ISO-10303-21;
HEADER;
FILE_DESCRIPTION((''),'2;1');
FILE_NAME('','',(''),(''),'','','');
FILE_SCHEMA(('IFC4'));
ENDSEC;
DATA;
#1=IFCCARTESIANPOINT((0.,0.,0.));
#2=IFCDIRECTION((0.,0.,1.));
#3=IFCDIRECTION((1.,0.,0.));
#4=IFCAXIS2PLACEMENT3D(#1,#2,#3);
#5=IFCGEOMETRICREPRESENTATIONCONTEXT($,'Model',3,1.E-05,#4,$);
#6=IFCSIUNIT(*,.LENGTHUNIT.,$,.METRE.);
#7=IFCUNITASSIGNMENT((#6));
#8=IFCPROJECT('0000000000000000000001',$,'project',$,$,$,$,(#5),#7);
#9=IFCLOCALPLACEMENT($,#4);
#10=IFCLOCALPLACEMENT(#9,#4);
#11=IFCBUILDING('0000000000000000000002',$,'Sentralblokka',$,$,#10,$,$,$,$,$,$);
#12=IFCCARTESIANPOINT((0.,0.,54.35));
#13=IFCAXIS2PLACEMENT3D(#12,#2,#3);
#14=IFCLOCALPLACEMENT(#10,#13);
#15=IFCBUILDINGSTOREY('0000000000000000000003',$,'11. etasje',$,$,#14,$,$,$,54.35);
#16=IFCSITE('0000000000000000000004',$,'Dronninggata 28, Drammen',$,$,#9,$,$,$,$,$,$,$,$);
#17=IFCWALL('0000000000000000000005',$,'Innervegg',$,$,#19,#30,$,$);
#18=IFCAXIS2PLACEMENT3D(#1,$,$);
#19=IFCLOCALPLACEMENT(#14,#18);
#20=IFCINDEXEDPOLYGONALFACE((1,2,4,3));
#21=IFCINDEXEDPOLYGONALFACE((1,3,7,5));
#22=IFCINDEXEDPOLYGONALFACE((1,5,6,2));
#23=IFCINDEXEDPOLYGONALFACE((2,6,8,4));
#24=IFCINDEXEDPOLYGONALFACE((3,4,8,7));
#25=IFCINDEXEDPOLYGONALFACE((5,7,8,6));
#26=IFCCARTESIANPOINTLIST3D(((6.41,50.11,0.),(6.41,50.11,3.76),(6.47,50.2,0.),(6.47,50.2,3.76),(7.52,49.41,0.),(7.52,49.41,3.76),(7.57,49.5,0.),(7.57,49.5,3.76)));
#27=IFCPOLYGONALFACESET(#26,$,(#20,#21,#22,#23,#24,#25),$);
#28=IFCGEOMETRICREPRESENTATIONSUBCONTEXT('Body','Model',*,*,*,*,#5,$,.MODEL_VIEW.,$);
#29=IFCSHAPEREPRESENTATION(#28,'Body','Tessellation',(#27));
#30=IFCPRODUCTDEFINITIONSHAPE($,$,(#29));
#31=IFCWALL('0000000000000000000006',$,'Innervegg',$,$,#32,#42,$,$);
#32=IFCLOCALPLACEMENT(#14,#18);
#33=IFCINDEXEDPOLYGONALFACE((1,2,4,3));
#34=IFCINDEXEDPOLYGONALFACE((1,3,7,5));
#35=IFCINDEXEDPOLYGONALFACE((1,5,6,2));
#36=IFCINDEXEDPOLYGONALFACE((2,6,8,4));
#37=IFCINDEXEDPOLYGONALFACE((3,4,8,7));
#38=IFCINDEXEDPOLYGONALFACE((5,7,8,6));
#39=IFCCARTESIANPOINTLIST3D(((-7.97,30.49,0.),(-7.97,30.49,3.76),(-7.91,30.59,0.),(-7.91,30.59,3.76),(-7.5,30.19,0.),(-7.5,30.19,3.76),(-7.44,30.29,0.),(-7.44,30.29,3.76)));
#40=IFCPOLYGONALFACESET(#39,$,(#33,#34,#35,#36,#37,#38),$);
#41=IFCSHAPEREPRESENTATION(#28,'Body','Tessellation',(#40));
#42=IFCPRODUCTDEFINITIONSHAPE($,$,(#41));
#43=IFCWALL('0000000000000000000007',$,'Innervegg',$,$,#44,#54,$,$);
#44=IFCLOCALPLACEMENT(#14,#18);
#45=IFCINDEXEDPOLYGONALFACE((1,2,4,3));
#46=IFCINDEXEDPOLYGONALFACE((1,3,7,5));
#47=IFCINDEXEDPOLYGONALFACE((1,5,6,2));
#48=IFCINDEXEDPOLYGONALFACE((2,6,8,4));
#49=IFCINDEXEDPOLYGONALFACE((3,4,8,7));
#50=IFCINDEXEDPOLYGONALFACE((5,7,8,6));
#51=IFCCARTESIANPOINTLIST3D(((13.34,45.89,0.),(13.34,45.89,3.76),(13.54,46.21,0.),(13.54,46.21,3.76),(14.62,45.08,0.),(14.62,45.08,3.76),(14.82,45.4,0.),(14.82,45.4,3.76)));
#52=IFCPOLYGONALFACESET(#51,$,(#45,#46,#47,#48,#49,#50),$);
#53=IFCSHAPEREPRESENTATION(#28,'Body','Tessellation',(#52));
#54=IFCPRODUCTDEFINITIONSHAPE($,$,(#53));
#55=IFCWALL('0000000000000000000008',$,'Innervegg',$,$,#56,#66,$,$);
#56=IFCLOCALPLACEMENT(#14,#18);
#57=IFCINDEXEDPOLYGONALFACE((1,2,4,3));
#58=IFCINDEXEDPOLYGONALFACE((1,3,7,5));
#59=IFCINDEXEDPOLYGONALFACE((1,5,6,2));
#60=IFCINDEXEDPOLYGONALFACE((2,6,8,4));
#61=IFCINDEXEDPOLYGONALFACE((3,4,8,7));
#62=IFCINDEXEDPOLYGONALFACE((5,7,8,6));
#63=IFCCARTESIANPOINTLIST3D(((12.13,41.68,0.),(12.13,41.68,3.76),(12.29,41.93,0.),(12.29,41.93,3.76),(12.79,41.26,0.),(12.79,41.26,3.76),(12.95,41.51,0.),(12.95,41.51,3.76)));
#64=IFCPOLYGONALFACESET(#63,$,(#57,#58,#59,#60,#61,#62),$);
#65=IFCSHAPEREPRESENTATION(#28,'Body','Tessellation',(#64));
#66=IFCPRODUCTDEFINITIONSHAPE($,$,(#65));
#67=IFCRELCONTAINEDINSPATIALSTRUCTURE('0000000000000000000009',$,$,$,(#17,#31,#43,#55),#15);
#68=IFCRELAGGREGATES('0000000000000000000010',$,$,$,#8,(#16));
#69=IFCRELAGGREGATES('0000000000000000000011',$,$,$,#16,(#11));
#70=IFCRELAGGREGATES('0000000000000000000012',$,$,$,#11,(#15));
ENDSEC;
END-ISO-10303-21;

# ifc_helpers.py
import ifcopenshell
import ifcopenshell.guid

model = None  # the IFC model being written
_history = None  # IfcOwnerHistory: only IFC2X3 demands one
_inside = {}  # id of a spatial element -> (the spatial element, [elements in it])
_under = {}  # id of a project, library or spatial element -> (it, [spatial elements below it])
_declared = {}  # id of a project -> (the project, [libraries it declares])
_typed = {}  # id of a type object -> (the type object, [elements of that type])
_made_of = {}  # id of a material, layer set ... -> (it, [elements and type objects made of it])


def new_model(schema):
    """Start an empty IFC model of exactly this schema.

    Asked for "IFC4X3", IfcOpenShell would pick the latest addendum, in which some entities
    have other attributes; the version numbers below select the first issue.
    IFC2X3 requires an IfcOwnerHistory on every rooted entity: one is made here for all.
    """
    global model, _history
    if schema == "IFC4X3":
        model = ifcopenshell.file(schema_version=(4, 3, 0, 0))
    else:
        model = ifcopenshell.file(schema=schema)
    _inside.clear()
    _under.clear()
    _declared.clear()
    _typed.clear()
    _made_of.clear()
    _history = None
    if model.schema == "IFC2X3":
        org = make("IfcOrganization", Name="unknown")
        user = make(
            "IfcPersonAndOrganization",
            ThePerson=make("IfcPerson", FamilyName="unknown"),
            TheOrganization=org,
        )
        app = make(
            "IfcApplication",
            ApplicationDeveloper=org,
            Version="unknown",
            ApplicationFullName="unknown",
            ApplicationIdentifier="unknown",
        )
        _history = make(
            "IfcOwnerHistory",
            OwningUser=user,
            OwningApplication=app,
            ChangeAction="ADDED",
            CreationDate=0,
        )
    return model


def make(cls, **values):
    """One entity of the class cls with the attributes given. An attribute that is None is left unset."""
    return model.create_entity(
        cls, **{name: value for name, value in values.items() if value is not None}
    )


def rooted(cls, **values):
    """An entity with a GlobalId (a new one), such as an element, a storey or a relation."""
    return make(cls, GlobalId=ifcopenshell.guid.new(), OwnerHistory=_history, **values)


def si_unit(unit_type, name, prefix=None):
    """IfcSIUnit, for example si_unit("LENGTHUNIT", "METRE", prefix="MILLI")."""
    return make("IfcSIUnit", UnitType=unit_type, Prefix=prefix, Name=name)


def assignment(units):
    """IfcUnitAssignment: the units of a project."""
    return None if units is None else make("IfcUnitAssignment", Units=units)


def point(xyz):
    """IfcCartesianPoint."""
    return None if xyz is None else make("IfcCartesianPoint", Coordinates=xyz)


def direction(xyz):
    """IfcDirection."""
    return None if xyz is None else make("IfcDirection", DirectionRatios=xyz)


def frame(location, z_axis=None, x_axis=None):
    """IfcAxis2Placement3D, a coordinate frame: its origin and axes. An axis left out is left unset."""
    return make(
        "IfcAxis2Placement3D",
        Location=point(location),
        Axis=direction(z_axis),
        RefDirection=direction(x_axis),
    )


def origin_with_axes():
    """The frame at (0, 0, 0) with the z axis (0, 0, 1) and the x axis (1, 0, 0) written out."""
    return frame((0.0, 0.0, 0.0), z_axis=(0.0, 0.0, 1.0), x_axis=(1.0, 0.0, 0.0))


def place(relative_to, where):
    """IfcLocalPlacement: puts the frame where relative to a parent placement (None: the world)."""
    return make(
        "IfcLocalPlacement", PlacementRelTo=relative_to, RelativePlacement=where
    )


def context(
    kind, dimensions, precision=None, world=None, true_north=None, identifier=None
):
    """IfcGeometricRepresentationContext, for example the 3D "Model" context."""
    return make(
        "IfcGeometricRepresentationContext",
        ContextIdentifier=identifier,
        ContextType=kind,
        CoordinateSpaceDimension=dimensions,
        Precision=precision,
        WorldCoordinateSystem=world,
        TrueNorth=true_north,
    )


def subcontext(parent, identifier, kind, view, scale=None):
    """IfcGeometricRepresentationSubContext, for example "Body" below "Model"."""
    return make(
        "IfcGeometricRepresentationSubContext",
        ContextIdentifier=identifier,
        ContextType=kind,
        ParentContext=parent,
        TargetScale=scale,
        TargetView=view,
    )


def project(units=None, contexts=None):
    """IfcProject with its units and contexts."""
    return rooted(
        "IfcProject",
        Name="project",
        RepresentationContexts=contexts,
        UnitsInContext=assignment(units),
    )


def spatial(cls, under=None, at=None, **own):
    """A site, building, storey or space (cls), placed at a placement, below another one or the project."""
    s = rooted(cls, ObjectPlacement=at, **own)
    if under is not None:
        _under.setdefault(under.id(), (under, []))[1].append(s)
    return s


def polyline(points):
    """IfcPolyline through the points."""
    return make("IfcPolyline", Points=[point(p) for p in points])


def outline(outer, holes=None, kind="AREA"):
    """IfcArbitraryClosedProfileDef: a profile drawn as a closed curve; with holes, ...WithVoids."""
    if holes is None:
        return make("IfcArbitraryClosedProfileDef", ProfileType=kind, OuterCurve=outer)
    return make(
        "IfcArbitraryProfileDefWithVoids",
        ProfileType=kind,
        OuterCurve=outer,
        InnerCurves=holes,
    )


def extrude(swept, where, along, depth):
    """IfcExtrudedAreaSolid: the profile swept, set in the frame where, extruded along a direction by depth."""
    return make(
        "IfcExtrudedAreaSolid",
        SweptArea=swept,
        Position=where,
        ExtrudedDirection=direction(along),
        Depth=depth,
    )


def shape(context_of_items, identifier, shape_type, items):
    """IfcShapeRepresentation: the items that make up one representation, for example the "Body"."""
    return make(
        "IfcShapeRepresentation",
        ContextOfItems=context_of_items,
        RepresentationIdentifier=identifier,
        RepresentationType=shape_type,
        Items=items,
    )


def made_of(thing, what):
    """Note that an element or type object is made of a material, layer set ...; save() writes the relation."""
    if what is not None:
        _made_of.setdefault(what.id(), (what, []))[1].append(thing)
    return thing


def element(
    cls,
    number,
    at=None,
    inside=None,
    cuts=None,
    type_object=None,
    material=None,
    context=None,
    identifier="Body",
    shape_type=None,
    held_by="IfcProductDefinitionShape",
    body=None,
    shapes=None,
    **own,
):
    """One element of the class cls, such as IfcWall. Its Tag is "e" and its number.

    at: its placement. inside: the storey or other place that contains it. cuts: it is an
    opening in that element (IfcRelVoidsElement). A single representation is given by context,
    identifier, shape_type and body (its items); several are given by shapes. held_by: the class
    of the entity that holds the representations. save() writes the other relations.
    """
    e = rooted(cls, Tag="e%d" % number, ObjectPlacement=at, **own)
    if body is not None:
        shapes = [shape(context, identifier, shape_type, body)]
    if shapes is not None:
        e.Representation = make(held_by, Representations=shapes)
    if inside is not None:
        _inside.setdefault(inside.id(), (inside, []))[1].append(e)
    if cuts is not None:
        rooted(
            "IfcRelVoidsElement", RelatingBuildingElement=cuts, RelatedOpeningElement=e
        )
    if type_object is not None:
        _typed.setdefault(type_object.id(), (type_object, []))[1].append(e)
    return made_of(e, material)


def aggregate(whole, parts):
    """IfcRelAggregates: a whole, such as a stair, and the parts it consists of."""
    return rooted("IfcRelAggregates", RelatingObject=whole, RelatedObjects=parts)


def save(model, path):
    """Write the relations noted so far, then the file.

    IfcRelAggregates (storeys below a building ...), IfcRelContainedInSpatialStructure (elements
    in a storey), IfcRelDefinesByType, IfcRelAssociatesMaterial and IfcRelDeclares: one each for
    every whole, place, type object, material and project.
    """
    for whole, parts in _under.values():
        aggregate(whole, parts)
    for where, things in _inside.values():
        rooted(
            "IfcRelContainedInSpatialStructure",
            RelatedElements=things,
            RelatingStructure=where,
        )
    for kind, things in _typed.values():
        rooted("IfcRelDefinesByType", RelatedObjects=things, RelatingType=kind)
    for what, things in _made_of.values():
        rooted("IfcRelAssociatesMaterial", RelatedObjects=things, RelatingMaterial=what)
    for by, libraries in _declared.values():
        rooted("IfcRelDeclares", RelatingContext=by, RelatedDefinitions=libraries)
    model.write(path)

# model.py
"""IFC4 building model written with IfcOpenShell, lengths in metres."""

from ifc_helpers import new_model, si_unit, frame, origin_with_axes, place, context, subcontext, project, spatial, polyline, outline, extrude, element, save


model = new_model("IFC4")

# Units and contexts
model_context = context("Model", 3, precision=1e-05, world=origin_with_axes())
body_context = subcontext(model_context, "Body", "Model", "MODEL_VIEW")
ifc_project = project(units=[si_unit("LENGTHUNIT", "METRE")], contexts=[model_context])

# Site, building, storey
site_placement = place(None, origin_with_axes())
site = spatial("IfcSite", under=ifc_project, at=site_placement, Name="Dronninggata 28, Drammen")
building_placement = place(site_placement, origin_with_axes())
building = spatial("IfcBuilding", under=site, at=building_placement, Name="Sentralblokka")
storey_placement = place(building_placement, frame((0.0, 0.0, 54.35), z_axis=(0.0, 0.0, 1.0), x_axis=(1.0, 0.0, 0.0)))
storey = spatial("IfcBuildingStorey", under=building, at=storey_placement, Name="11. etasje", Elevation=54.35)

# Walls
wall_1_placement = place(storey_placement, frame((0.0, 0.0, -54.35), z_axis=(0.0, 0.0, 1.0), x_axis=(1.0, 0.0, 0.0)))
element("IfcWall", 1, at=wall_1_placement, inside=storey, Name="Innervegg", context=body_context, shape_type="SweptSolid", body=[
    extrude(outline(polyline([(7.57, 49.5), (7.52, 49.41), (6.41, 50.11), (6.47, 50.2), (7.57, 49.5)])), frame((0.0, 0.0, 54.35)), (0.0, 0.0, 1.0), 3.76),
])
wall_2_placement = place(storey_placement, frame((0.0, 0.0, -54.35), z_axis=(0.0, 0.0, 1.0), x_axis=(1.0, 0.0, 0.0)))
element("IfcWall", 2, at=wall_2_placement, inside=storey, Name="Innervegg", context=body_context, shape_type="SweptSolid", body=[
    extrude(outline(polyline([(-7.44, 30.29), (-7.5, 30.19), (-7.97, 30.49), (-7.91, 30.59), (-7.44, 30.29)])), frame((0.0, 0.0, 54.35)), (0.0, 0.0, 1.0), 3.76),
])
wall_3_placement = place(storey_placement, frame((0.0, 0.0, -54.35), z_axis=(0.0, 0.0, 1.0), x_axis=(1.0, 0.0, 0.0)))
element("IfcWall", 3, at=wall_3_placement, inside=storey, Name="Innervegg", context=body_context, shape_type="SweptSolid", body=[
    extrude(outline(polyline([(14.82, 45.4), (14.62, 45.08), (13.34, 45.89), (13.54, 46.21), (14.82, 45.4)])), frame((0.0, 0.0, 54.35)), (0.0, 0.0, 1.0), 3.76),
])
wall_4_placement = place(storey_placement, frame((0.0, 0.0, -54.35), z_axis=(0.0, 0.0, 1.0), x_axis=(1.0, 0.0, 0.0)))
element("IfcWall", 4, at=wall_4_placement, inside=storey, Name="Innervegg", context=body_context, shape_type="SweptSolid", body=[
    extrude(outline(polyline([(12.95, 41.51), (12.79, 41.26), (12.13, 41.68), (12.29, 41.93), (12.95, 41.51)])), frame((0.0, 0.0, 54.35)), (0.0, 0.0, 1.0), 3.76),
])

save(model, "model.ifc")
